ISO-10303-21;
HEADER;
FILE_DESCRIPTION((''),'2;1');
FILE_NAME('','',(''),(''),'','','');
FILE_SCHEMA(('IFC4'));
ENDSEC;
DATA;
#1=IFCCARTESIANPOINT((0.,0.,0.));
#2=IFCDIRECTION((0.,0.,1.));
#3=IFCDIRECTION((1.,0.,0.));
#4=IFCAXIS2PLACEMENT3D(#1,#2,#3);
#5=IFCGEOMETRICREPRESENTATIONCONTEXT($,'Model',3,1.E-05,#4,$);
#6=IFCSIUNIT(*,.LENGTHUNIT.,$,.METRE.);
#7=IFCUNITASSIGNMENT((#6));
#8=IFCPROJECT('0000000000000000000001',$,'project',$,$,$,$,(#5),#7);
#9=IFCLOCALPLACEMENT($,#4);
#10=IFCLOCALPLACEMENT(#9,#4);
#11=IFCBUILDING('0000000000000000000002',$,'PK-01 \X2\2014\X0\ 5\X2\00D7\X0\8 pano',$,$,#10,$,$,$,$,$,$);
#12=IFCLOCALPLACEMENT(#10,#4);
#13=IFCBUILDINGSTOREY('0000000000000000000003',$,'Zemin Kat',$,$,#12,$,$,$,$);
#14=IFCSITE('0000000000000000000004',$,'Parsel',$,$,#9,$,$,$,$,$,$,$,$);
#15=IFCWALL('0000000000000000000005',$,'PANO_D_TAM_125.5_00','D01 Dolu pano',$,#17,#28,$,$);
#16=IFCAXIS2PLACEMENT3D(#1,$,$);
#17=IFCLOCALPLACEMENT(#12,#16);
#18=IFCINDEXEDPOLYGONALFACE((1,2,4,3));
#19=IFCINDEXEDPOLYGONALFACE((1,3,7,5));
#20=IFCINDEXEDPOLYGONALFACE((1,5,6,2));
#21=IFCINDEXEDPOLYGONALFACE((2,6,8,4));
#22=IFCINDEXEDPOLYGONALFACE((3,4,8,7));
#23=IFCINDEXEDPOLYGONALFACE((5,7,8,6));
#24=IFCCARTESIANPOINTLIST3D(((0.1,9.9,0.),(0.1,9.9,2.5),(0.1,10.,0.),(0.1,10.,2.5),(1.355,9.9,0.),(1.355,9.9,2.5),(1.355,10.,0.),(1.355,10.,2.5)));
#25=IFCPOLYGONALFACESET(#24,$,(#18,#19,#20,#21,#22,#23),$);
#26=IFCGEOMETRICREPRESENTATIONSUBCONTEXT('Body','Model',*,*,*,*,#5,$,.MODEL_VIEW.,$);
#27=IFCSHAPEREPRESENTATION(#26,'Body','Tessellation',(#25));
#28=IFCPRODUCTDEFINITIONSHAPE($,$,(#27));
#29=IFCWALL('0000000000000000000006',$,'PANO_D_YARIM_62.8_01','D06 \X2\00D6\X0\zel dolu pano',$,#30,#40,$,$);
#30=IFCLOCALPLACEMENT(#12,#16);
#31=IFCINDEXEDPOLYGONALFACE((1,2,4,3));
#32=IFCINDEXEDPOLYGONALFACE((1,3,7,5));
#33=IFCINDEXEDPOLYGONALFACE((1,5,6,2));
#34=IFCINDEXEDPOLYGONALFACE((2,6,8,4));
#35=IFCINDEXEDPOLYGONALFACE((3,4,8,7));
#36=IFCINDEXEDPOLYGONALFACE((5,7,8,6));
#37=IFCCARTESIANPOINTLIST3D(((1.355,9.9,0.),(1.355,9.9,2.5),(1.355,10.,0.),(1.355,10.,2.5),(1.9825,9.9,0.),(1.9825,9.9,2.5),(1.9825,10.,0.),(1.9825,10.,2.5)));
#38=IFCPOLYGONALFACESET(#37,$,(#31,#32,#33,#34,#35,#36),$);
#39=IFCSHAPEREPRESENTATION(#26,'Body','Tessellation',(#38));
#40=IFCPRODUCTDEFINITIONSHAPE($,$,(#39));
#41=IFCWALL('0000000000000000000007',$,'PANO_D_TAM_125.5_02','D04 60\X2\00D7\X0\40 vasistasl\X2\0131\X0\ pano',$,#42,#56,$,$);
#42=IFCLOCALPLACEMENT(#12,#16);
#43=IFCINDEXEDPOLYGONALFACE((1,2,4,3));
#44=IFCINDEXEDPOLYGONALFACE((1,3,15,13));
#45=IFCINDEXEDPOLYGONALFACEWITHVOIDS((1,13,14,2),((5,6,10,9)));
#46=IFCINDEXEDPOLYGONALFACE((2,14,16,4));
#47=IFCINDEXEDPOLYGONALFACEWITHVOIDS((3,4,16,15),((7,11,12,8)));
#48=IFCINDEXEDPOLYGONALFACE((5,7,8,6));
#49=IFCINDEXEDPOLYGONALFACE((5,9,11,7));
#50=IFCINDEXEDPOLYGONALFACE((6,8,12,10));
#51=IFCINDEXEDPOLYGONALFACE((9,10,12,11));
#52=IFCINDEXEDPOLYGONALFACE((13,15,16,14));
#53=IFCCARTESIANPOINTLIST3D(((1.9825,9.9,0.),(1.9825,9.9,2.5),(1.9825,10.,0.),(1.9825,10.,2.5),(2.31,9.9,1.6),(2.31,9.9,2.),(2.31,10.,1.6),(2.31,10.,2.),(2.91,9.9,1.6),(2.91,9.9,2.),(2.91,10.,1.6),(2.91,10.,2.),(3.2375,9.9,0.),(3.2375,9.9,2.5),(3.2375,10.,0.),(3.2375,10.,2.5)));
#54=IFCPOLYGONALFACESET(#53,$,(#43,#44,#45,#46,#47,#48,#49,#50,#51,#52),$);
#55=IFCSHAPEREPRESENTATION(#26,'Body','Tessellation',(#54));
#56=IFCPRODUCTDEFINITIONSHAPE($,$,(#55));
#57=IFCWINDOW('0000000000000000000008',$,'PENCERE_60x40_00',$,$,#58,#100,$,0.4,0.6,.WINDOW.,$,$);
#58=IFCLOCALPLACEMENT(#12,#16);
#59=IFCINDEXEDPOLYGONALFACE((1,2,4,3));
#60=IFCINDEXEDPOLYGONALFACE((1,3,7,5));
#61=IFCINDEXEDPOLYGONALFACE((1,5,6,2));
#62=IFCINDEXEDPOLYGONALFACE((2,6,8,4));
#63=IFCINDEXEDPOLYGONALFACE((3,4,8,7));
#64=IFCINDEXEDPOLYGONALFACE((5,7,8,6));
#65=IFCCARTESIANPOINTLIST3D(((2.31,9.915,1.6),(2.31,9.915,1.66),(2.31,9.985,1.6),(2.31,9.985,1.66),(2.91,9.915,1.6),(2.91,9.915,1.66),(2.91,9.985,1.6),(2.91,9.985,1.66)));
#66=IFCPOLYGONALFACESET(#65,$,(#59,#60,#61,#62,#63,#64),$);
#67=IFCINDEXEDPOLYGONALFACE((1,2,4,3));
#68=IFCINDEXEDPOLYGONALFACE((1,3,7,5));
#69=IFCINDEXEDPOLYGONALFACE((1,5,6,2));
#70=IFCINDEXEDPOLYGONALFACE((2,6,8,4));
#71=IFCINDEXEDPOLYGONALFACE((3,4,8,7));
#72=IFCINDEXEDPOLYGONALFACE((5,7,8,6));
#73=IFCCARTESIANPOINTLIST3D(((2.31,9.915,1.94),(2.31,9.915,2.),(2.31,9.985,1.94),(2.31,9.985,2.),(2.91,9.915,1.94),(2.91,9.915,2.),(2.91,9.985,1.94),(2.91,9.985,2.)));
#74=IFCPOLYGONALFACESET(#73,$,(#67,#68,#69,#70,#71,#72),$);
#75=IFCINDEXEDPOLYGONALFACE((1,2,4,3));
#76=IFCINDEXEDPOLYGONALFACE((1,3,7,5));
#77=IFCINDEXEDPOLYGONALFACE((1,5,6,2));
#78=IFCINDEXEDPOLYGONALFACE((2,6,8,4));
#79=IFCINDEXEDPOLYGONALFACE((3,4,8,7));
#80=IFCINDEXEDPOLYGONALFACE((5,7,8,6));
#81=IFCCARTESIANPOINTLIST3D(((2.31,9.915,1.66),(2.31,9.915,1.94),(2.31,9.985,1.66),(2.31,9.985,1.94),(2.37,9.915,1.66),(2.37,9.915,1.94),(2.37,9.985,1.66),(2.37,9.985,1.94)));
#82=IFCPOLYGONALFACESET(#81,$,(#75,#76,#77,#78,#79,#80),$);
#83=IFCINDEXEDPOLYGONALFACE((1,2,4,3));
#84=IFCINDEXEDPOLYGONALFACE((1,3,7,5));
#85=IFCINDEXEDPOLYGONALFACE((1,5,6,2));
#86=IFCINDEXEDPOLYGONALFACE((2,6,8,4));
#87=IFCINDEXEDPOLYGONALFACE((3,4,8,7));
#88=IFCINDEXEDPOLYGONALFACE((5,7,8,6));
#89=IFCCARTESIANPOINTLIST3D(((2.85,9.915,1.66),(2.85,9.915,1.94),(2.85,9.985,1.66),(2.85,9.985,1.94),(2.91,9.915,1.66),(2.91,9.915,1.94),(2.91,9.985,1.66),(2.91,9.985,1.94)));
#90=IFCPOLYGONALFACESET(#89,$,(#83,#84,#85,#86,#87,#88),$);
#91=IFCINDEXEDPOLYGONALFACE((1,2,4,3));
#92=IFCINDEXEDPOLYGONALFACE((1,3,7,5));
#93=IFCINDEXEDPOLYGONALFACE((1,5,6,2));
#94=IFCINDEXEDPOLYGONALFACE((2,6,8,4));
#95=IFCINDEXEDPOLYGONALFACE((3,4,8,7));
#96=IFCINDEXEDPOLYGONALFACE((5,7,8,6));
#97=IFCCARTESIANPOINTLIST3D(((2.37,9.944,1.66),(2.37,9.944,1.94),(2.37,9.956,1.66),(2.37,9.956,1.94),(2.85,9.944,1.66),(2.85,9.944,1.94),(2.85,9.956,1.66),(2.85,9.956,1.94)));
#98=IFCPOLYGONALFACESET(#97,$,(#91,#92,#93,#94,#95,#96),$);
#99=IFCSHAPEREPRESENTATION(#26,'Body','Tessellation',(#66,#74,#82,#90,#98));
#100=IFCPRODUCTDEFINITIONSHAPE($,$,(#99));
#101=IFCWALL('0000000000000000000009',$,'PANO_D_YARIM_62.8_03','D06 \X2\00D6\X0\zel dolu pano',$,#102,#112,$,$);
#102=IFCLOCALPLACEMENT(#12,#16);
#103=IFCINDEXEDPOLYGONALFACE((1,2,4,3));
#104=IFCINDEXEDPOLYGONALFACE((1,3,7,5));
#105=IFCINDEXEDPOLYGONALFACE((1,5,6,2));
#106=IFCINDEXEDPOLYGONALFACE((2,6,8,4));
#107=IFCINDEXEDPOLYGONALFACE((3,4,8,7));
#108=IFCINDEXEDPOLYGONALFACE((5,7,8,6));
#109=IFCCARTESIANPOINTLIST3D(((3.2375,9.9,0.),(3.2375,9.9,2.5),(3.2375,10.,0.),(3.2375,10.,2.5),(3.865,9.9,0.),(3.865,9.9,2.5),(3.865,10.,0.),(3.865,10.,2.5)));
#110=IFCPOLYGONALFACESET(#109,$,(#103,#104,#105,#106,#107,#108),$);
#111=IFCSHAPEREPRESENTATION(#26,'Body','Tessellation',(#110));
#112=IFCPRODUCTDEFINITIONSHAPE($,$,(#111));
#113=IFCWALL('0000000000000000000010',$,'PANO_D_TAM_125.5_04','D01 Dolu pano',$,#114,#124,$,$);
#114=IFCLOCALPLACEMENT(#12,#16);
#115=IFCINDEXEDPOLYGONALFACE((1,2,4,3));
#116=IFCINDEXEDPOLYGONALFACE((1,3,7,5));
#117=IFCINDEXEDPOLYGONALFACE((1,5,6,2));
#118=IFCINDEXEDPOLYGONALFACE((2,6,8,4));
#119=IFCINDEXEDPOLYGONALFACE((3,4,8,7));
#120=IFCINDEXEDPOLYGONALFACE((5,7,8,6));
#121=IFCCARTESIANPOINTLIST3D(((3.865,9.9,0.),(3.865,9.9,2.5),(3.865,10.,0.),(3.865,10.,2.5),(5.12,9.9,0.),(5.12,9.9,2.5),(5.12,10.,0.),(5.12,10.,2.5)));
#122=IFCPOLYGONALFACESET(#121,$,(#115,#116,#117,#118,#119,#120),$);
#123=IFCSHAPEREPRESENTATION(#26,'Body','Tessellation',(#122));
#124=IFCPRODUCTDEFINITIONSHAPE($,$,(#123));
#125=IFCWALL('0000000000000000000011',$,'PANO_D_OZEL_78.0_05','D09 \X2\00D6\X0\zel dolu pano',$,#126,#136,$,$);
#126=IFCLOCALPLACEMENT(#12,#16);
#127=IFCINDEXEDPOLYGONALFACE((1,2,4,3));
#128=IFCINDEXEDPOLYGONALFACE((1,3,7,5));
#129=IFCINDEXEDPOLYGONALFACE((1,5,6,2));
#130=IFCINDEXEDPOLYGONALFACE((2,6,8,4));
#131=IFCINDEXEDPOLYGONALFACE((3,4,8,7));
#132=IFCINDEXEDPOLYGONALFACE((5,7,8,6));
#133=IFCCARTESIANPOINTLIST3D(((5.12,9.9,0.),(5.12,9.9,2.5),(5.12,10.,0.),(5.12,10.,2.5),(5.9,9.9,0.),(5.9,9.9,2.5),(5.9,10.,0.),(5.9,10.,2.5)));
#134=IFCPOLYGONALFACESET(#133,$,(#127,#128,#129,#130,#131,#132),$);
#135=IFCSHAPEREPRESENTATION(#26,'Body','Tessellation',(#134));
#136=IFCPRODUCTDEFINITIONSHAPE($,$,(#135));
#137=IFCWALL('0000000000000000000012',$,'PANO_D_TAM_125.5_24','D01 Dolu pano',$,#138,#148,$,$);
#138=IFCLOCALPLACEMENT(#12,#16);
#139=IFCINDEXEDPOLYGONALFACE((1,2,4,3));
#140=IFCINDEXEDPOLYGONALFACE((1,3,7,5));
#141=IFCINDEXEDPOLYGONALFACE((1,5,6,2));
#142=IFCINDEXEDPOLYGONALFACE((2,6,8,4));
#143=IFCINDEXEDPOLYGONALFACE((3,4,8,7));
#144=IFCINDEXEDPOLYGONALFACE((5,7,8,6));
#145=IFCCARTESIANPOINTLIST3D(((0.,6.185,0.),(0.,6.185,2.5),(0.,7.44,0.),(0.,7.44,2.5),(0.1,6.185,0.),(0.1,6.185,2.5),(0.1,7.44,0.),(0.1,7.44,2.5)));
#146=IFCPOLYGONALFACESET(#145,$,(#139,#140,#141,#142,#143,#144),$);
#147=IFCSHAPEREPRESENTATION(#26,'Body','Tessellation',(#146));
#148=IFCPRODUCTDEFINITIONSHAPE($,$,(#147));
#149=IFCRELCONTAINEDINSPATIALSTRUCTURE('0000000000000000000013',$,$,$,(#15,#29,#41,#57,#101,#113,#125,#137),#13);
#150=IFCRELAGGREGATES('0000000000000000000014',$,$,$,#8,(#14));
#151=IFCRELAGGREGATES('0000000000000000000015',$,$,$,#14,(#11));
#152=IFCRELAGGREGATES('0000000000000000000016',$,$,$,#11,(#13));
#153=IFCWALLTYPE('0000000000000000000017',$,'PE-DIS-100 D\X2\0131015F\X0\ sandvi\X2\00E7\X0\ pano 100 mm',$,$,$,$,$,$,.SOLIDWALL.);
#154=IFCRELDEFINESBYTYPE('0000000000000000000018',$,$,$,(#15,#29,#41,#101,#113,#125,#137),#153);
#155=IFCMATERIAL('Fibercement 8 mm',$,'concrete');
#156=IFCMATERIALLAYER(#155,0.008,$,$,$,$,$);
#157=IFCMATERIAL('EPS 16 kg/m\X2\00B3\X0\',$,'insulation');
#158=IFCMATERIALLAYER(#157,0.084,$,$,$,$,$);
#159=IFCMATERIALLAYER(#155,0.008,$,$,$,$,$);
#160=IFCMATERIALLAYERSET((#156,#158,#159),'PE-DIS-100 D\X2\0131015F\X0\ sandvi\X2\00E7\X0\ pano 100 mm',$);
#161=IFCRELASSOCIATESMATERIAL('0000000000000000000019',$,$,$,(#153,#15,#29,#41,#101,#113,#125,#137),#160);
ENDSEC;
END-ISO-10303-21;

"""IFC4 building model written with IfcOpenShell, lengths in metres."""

from ifc_helpers import new_model, si_unit, frame, origin_with_axes, place, context, subcontext, project, spatial, line, indexed_curve, outline, extrude, material, layer, layer_set, layer_usage, type_object, element, fill, save


model = new_model("IFC4")

# Units and contexts
model_context = context("Model", 3, precision=1e-05, world=origin_with_axes())
body_context = subcontext(model_context, "Body", "Model", "MODEL_VIEW")
ifc_project = project(units=[si_unit("LENGTHUNIT", "METRE")], contexts=[model_context])

# Site, building, storey
site_placement = place(None, origin_with_axes())
site = spatial("IfcSite", under=ifc_project, at=site_placement, Name="Parsel")
building_placement = place(site_placement, origin_with_axes())
building = spatial("IfcBuilding", under=site, at=building_placement, Name="PK-01 — 5×8 pano")
storey_placement = place(building_placement, origin_with_axes())
storey = spatial("IfcBuildingStorey", under=building, at=storey_placement, Name="Zemin Kat")

# Walls
ifc_material_1 = material(Name="Fibercement 8 mm", Category="concrete")
ifc_layer_1 = layer(ifc_material_1, 0.008)
ifc_material_2 = material(Name="EPS 16 kg/m³", Category="insulation")
ifc_layer_2 = layer(ifc_material_2, 0.084)
ifc_layer_3 = layer(ifc_material_1, 0.008)
ifc_layer_set_1 = layer_set([ifc_layer_1, ifc_layer_2, ifc_layer_3], Name="PE-DIS-100 Dış sandviç pano 100 mm")
ifc_layer_usage_1 = layer_usage(ifc_layer_set_1, "AXIS2", "POSITIVE", 0.0)
wall_type_1 = type_object("IfcWallType", Name="PE-DIS-100 Dış sandviç pano 100 mm", PredefinedType="SOLIDWALL", material=ifc_layer_set_1)
wall_1_placement = place(storey_placement, frame((0.1, 9.9, 0.0), z_axis=(0.0, 0.0, 1.0), x_axis=(1.0, 0.0, 0.0)))
element("IfcWall", 1, at=wall_1_placement, inside=storey, type_object=wall_type_1, material=ifc_layer_usage_1, Name="PANO_D_TAM_125.5_00", Description="D01 Dolu pano", context=body_context, shape_type="SweptSolid", body=[
    extrude(outline(indexed_curve([(0.0, 0.0), (1.255, 0.0), (1.255, 0.1), (0.0, 0.1)], segments=[line(1, 2, 3, 4, 1)])), origin_with_axes(), (0.0, 0.0, 1.0), 2.5),
])
ifc_layer_usage_2 = layer_usage(ifc_layer_set_1, "AXIS2", "POSITIVE", 0.0)
wall_2_placement = place(storey_placement, frame((1.355, 9.9, 0.0), z_axis=(0.0, 0.0, 1.0), x_axis=(1.0, 0.0, 0.0)))
element("IfcWall", 2, at=wall_2_placement, inside=storey, type_object=wall_type_1, material=ifc_layer_usage_2, Name="PANO_D_YARIM_62.8_01", Description="D06 Özel dolu pano", context=body_context, shape_type="SweptSolid", body=[
    extrude(outline(indexed_curve([(0.0, 0.0), (0.6275, 0.0), (0.6275, 0.1), (0.0, 0.1)], segments=[line(1, 2, 3, 4, 1)])), origin_with_axes(), (0.0, 0.0, 1.0), 2.5),
])

# Wall, opening, window
ifc_layer_usage_3 = layer_usage(ifc_layer_set_1, "AXIS2", "POSITIVE", 0.0)
wall_3_placement = place(storey_placement, frame((1.9825, 9.9, 0.0), z_axis=(0.0, 0.0, 1.0), x_axis=(1.0, 0.0, 0.0)))
wall_3 = element("IfcWall", 3, at=wall_3_placement, inside=storey, type_object=wall_type_1, material=ifc_layer_usage_3, Name="PANO_D_TAM_125.5_02", Description="D04 60×40 vasistaslı pano", context=body_context, shape_type="SweptSolid", body=[
    extrude(outline(indexed_curve([(0.0, 0.0), (1.255, 0.0), (1.255, 0.1), (0.0, 0.1)], segments=[line(1, 2, 3, 4, 1)])), origin_with_axes(), (0.0, 0.0, 1.0), 2.5),
])
opening_1_placement = place(wall_3_placement, origin_with_axes())
opening_1 = element("IfcOpeningElement", 4, at=opening_1_placement, cuts=wall_3, PredefinedType="OPENING", context=body_context, shape_type="SweptSolid", body=[
    extrude(outline(indexed_curve([(0.0, 0.0), (0.6, 0.0), (0.6, 0.14), (0.0, 0.14)], segments=[line(1, 2, 3, 4, 1)])), frame((0.3275, -0.02, 1.6), z_axis=(0.0, 0.0, 1.0), x_axis=(1.0, 0.0, 0.0)), (0.0, 0.0, 1.0), 0.4),
])
window_1_placement = place(storey_placement, frame((1.9825, 9.9, 0.0), z_axis=(0.0, 0.0, 1.0), x_axis=(1.0, 0.0, 0.0)))
window_1 = element("IfcWindow", 5, at=window_1_placement, inside=storey, Name="PENCERE_60x40_00", OverallHeight=0.4, OverallWidth=0.6, PredefinedType="WINDOW", context=body_context, shape_type="SweptSolid", body=[
    extrude(outline(indexed_curve([(0.0, 0.0), (0.6, 0.0), (0.6, 0.07), (0.0, 0.07)], segments=[line(1, 2, 3, 4, 1)])), frame((0.3275, 0.015, 1.6), z_axis=(0.0, 0.0, 1.0), x_axis=(1.0, 0.0, 0.0)), (0.0, 0.0, 1.0), 0.06),
    extrude(outline(indexed_curve([(0.0, 0.0), (0.6, 0.0), (0.6, 0.07), (0.0, 0.07)], segments=[line(1, 2, 3, 4, 1)])), frame((0.3275, 0.015, 1.94), z_axis=(0.0, 0.0, 1.0), x_axis=(1.0, 0.0, 0.0)), (0.0, 0.0, 1.0), 0.06),
    extrude(outline(indexed_curve([(0.0, 0.0), (0.06, 0.0), (0.06, 0.07), (0.0, 0.07)], segments=[line(1, 2, 3, 4, 1)])), frame((0.3275, 0.015, 1.66), z_axis=(0.0, 0.0, 1.0), x_axis=(1.0, 0.0, 0.0)), (0.0, 0.0, 1.0), 0.28),
    extrude(outline(indexed_curve([(0.0, 0.0), (0.06, 0.0), (0.06, 0.07), (0.0, 0.07)], segments=[line(1, 2, 3, 4, 1)])), frame((0.8675, 0.015, 1.66), z_axis=(0.0, 0.0, 1.0), x_axis=(1.0, 0.0, 0.0)), (0.0, 0.0, 1.0), 0.28),
    extrude(outline(indexed_curve([(0.0, 0.0), (0.48, 0.0), (0.48, 0.012), (0.0, 0.012)], segments=[line(1, 2, 3, 4, 1)])), frame((0.3875, 0.044, 1.66), z_axis=(0.0, 0.0, 1.0), x_axis=(1.0, 0.0, 0.0)), (0.0, 0.0, 1.0), 0.28),
])
fill(opening_1, window_1)

# Walls
ifc_layer_usage_4 = layer_usage(ifc_layer_set_1, "AXIS2", "POSITIVE", 0.0)
wall_4_placement = place(storey_placement, frame((3.2375, 9.9, 0.0), z_axis=(0.0, 0.0, 1.0), x_axis=(1.0, 0.0, 0.0)))
element("IfcWall", 6, at=wall_4_placement, inside=storey, type_object=wall_type_1, material=ifc_layer_usage_4, Name="PANO_D_YARIM_62.8_03", Description="D06 Özel dolu pano", context=body_context, shape_type="SweptSolid", body=[
    extrude(outline(indexed_curve([(0.0, 0.0), (0.6275, 0.0), (0.6275, 0.1), (0.0, 0.1)], segments=[line(1, 2, 3, 4, 1)])), origin_with_axes(), (0.0, 0.0, 1.0), 2.5),
])
ifc_layer_usage_5 = layer_usage(ifc_layer_set_1, "AXIS2", "POSITIVE", 0.0)
wall_5_placement = place(storey_placement, frame((3.865, 9.9, 0.0), z_axis=(0.0, 0.0, 1.0), x_axis=(1.0, 0.0, 0.0)))
element("IfcWall", 7, at=wall_5_placement, inside=storey, type_object=wall_type_1, material=ifc_layer_usage_5, Name="PANO_D_TAM_125.5_04", Description="D01 Dolu pano", context=body_context, shape_type="SweptSolid", body=[
    extrude(outline(indexed_curve([(0.0, 0.0), (1.255, 0.0), (1.255, 0.1), (0.0, 0.1)], segments=[line(1, 2, 3, 4, 1)])), origin_with_axes(), (0.0, 0.0, 1.0), 2.5),
])
ifc_layer_usage_6 = layer_usage(ifc_layer_set_1, "AXIS2", "POSITIVE", 0.0)
wall_6_placement = place(storey_placement, frame((5.12, 9.9, 0.0), z_axis=(0.0, 0.0, 1.0), x_axis=(1.0, 0.0, 0.0)))
element("IfcWall", 8, at=wall_6_placement, inside=storey, type_object=wall_type_1, material=ifc_layer_usage_6, Name="PANO_D_OZEL_78.0_05", Description="D09 Özel dolu pano", context=body_context, shape_type="SweptSolid", body=[
    extrude(outline(indexed_curve([(0.0, 0.0), (0.78, 0.0), (0.78, 0.1), (0.0, 0.1)], segments=[line(1, 2, 3, 4, 1)])), origin_with_axes(), (0.0, 0.0, 1.0), 2.5),
])
ifc_layer_usage_7 = layer_usage(ifc_layer_set_1, "AXIS2", "POSITIVE", 0.0)
wall_7_placement = place(storey_placement, frame((0.1, 6.185, 0.0), z_axis=(0.0, 0.0, 1.0), x_axis=(0.0, 1.0, 0.0)))
element("IfcWall", 9, at=wall_7_placement, inside=storey, type_object=wall_type_1, material=ifc_layer_usage_7, Name="PANO_D_TAM_125.5_24", Description="D01 Dolu pano", context=body_context, shape_type="SweptSolid", body=[
    extrude(outline(indexed_curve([(0.0, 0.0), (1.255, 0.0), (1.255, 0.1), (0.0, 0.1)], segments=[line(1, 2, 3, 4, 1)])), origin_with_axes(), (0.0, 0.0, 1.0), 2.5),
])

save(model, "model.ifc")
